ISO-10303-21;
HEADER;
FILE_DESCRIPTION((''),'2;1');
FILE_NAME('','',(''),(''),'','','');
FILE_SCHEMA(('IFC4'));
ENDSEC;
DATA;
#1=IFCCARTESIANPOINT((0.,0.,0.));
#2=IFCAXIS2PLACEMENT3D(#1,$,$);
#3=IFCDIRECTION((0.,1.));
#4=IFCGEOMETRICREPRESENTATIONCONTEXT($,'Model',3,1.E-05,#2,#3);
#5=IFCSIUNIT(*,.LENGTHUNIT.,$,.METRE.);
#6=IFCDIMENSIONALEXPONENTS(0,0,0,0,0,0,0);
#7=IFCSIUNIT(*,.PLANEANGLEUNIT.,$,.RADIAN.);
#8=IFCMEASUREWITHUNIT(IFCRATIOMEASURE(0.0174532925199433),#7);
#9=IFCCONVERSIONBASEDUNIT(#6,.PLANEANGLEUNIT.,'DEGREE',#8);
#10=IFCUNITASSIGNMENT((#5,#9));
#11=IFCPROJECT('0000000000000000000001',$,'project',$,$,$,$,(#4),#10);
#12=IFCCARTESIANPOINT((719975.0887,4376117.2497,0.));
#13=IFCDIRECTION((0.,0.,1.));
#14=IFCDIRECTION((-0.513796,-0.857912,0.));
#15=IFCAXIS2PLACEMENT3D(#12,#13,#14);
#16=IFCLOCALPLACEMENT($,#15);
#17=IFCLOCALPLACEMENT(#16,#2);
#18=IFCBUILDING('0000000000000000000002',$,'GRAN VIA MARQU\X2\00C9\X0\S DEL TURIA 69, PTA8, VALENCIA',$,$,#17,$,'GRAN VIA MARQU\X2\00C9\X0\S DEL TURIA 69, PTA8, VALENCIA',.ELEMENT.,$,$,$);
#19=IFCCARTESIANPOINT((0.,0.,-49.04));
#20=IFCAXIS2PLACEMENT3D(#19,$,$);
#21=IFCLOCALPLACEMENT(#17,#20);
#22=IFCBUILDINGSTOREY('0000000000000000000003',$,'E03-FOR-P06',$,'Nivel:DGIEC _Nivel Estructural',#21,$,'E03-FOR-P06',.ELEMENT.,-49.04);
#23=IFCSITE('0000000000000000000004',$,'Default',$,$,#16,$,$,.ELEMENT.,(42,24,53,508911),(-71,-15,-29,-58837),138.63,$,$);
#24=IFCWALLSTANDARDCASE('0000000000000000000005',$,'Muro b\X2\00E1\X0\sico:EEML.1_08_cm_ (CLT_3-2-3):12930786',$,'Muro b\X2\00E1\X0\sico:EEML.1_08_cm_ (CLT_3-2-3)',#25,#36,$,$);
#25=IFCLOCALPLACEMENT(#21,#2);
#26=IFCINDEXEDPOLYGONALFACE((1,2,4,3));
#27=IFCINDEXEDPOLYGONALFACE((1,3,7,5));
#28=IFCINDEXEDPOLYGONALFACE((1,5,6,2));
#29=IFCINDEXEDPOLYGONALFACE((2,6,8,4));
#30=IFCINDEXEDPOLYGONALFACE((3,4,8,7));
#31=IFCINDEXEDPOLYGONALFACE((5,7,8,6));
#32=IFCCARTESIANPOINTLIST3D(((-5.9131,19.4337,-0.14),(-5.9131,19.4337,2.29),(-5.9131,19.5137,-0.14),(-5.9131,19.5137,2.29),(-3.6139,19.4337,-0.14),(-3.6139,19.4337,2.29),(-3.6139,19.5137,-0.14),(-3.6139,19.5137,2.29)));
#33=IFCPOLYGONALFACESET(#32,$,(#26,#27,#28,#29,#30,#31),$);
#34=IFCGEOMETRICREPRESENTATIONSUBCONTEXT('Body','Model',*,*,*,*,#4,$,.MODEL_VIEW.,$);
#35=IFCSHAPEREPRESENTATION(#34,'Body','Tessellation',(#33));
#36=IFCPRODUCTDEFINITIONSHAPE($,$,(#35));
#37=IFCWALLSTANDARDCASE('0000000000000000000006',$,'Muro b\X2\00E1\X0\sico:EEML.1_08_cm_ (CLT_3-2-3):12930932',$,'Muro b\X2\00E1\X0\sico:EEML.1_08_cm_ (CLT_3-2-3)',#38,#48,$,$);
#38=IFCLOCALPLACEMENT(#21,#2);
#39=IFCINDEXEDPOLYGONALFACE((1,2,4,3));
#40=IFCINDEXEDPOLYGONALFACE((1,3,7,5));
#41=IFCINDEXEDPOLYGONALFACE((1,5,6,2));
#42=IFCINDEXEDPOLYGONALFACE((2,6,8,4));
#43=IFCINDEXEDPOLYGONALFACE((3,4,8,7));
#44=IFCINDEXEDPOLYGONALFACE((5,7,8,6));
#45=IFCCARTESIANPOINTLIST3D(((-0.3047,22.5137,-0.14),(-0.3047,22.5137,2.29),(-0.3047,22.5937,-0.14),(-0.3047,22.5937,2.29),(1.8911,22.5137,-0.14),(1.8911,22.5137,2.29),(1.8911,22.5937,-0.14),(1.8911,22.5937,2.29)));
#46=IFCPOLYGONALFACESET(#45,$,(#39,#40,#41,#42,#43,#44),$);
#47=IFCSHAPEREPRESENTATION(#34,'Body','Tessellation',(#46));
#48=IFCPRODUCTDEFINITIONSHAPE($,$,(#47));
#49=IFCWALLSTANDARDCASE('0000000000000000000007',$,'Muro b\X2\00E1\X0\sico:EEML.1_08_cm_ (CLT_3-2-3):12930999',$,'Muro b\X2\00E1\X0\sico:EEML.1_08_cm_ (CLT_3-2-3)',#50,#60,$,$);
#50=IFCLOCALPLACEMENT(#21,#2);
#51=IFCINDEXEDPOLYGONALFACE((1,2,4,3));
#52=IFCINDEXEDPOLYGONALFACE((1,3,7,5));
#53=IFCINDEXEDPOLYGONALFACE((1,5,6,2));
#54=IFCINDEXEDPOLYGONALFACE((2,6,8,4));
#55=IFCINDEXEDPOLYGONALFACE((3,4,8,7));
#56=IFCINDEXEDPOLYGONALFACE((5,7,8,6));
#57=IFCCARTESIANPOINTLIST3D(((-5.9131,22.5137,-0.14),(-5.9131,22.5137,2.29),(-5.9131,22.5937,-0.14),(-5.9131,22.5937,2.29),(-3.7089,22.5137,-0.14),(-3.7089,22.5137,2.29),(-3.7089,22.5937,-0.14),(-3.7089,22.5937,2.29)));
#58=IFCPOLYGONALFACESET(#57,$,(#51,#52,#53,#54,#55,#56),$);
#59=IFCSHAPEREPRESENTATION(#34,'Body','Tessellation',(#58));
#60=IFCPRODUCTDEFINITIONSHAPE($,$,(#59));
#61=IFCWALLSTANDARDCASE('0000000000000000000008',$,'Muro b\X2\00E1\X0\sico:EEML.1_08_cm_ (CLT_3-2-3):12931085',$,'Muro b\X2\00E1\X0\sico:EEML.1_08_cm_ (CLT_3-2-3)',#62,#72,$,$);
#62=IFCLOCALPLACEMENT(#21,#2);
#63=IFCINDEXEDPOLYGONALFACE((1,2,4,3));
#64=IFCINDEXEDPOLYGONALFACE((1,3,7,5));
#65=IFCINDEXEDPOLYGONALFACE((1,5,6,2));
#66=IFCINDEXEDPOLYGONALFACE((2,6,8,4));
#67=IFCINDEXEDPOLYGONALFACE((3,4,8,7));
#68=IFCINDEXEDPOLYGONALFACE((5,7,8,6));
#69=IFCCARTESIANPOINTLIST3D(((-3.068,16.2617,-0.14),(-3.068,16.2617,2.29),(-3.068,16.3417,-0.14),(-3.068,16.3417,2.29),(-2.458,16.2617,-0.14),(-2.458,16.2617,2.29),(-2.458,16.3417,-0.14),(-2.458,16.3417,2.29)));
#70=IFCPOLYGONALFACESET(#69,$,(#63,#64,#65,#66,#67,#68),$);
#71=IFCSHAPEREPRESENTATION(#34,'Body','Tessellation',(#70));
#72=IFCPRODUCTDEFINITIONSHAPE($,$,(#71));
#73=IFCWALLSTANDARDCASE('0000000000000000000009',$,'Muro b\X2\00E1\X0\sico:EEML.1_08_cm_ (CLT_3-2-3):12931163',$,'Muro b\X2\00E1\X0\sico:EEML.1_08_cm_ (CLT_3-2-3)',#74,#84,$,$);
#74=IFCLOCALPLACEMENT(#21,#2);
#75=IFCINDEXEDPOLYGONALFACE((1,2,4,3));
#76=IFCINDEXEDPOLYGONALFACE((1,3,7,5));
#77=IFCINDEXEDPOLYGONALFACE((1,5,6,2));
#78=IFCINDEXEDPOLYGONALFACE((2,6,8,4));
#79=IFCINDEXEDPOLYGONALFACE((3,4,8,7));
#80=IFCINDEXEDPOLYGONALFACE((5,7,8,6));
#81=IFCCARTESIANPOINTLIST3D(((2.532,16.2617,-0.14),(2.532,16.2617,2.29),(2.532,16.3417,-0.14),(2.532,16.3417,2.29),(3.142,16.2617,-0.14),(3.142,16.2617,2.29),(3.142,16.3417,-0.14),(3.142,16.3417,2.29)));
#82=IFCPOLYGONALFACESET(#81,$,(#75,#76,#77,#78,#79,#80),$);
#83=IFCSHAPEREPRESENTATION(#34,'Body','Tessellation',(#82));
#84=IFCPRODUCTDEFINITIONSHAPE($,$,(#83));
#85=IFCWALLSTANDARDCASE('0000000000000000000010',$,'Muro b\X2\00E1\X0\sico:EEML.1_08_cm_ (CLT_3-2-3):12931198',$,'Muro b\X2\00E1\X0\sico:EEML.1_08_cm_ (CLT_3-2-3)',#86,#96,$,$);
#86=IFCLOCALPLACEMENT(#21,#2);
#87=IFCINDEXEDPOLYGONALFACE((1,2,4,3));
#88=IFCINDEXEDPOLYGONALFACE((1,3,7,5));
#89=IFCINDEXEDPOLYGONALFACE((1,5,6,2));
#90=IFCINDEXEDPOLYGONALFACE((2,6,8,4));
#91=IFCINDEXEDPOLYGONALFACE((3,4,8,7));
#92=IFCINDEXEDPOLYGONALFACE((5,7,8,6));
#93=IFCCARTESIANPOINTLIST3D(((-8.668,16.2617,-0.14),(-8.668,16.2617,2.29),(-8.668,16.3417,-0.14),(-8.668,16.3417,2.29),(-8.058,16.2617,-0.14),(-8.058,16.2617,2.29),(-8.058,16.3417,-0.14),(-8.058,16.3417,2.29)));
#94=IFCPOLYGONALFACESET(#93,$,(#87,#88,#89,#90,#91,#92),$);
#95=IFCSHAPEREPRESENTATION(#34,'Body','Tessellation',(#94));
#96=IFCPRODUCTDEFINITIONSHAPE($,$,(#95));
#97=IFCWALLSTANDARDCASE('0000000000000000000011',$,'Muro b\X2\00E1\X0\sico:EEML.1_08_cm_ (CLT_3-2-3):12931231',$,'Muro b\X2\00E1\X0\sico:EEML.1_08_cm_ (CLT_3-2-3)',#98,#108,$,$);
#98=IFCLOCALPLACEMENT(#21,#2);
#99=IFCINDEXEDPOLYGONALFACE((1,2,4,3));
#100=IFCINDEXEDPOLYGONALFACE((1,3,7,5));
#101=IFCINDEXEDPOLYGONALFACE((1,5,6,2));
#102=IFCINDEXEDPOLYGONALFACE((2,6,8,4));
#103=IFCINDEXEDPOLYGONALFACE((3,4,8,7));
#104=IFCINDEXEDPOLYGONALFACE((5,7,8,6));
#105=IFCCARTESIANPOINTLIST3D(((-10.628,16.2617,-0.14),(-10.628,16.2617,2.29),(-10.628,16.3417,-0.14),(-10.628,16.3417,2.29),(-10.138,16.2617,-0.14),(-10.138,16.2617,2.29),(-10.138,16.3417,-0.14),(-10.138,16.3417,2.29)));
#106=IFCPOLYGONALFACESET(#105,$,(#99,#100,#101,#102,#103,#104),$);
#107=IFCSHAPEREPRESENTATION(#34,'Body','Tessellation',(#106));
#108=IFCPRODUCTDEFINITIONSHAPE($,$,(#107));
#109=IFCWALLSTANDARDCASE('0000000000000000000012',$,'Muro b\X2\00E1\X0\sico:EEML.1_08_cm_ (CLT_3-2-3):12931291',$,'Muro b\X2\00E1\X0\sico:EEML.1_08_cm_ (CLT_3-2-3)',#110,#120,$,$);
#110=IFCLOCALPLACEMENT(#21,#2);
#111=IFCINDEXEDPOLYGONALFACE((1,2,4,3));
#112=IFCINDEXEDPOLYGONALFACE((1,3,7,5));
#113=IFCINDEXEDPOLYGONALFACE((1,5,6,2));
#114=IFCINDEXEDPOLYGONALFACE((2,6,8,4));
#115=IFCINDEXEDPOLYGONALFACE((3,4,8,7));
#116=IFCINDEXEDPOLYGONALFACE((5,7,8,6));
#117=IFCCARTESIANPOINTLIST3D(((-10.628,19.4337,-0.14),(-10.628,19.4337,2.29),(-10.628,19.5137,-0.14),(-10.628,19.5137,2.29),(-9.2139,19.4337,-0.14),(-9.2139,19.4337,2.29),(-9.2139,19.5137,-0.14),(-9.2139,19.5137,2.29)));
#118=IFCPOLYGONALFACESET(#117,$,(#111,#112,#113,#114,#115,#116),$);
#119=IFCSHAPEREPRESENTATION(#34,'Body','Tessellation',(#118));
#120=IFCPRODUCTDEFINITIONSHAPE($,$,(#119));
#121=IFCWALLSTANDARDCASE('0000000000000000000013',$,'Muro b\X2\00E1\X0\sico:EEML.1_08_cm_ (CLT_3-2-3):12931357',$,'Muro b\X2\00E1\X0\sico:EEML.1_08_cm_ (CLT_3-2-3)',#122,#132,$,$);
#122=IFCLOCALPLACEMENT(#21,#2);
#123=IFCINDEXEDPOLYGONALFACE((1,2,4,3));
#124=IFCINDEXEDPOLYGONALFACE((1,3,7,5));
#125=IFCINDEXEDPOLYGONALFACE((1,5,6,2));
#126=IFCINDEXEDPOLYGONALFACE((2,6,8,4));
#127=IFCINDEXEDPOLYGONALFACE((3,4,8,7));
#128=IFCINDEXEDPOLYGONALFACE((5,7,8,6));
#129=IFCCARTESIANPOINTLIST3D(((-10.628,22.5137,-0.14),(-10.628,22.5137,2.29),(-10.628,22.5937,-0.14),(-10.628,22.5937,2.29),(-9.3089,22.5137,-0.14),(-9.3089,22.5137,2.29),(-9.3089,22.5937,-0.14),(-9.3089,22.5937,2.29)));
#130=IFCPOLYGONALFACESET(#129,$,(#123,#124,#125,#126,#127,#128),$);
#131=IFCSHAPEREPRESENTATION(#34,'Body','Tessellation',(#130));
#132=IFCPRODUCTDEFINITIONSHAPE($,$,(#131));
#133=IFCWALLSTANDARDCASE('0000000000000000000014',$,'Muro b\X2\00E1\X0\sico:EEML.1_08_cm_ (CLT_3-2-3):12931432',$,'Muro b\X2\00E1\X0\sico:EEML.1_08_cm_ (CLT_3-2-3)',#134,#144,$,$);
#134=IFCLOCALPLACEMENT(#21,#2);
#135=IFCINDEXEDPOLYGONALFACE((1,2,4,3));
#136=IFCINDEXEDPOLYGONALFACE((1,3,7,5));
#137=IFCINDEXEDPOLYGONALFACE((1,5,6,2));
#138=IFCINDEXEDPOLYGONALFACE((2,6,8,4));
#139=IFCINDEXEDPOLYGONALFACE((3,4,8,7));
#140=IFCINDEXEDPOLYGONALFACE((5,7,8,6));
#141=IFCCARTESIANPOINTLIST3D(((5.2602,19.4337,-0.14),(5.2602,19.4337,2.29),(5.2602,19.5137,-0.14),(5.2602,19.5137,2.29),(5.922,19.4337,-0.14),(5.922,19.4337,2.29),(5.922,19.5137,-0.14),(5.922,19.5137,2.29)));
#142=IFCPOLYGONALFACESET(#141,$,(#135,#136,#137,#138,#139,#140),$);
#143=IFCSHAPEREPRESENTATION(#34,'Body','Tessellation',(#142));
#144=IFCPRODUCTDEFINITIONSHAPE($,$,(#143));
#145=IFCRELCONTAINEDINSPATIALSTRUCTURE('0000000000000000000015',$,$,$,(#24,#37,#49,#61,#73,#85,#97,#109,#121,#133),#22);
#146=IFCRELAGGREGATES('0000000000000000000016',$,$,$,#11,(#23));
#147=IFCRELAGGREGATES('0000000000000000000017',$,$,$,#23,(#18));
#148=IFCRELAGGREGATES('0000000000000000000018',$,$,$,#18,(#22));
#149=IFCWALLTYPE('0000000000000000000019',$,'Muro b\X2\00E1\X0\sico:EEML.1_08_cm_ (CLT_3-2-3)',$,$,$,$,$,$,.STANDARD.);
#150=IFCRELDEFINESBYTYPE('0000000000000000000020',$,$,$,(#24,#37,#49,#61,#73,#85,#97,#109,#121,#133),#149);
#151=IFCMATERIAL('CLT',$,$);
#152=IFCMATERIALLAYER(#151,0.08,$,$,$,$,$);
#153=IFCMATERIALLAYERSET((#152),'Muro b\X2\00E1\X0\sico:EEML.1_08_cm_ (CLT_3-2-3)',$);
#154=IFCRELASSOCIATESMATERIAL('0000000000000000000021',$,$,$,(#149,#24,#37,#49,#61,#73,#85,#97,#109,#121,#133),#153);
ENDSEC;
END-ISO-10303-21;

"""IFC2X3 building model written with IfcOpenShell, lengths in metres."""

from ifc_helpers import new_model, entity, si_unit, converted_unit, direction, frame, frame_2d, origin, place, context, subcontext, project, spatial, rectangle, extrude, material, layer, layer_set, layer_usage, type_object, element, save


model = new_model("IFC2X3")

# Units and contexts
model_context = context("Model", 3, precision=1e-05, world=origin(), true_north=direction((0.0, 1.0)))
body_context = subcontext(model_context, "Body", "Model", "MODEL_VIEW")
ifc_project = project(units=[si_unit("LENGTHUNIT", "METRE"), converted_unit("PLANEANGLEUNIT", "DEGREE", entity("IfcRatioMeasure", 0.0174532925199433), si_unit("PLANEANGLEUNIT", "RADIAN"), dimensions=[0, 0, 0, 0, 0, 0, 0])], contexts=[model_context])

# Site, building, storey
site_placement = place(None, frame((719975.0887, 4376117.2497, 0.0), z_axis=(0.0, 0.0, 1.0), x_axis=(-0.513796, -0.857912, 0.0)))
site = spatial("IfcSite", under=ifc_project, at=site_placement, Name="Default", CompositionType="ELEMENT", RefLatitude=(42, 24, 53, 508911), RefLongitude=(-71, -15, -29, -58837), RefElevation=138.63)
building_placement = place(site_placement, origin())
building = spatial("IfcBuilding", under=site, at=building_placement, Name="GRAN VIA MARQUÉS DEL TURIA 69, PTA8, VALENCIA", LongName="GRAN VIA MARQUÉS DEL TURIA 69, PTA8, VALENCIA", CompositionType="ELEMENT")
storey_placement = place(building_placement, frame((0.0, 0.0, -49.04)))
storey = spatial("IfcBuildingStorey", under=building, at=storey_placement, Name="E03-FOR-P06", ObjectType="Nivel:DGIEC _Nivel Estructural", LongName="E03-FOR-P06", CompositionType="ELEMENT", Elevation=-49.04)

# Shared definitions
ifc_material = material(Name="CLT")

# Walls
ifc_layer_1 = layer(ifc_material, 0.08)
ifc_layer_set_1 = layer_set([ifc_layer_1], Name="Muro básico:EEML.1_08_cm_ (CLT_3-2-3)")
wall_type = type_object("IfcWallType", Name="Muro básico:EEML.1_08_cm_ (CLT_3-2-3)", PredefinedType="STANDARD", material=ifc_layer_set_1)
ifc_layer_usage_1 = layer_usage(ifc_layer_set_1, "AXIS2", "NEGATIVE", 0.04)
wall_1_placement = place(storey_placement, frame((-3.6139, 19.4737, -0.14), z_axis=(0.0, 0.0, 1.0), x_axis=(-1.0, 0.0, 0.0)))
element("IfcWallStandardCase", 1, at=wall_1_placement, inside=storey, type_object=wall_type, material=ifc_layer_usage_1, Name="Muro básico:EEML.1_08_cm_ (CLT_3-2-3):12930786", ObjectType="Muro básico:EEML.1_08_cm_ (CLT_3-2-3)", context=body_context, shape_type="SweptSolid", body=[
    extrude(rectangle(XDim=2.2992, YDim=0.08, at=frame_2d((1.1496, 0.0), x_axis=(-1.0, 0.0))), origin(), (0.0, 0.0, 1.0), 2.43),
])
ifc_layer_usage_2 = layer_usage(ifc_layer_set_1, "AXIS2", "NEGATIVE", 0.04)
wall_2_placement = place(storey_placement, frame((1.8911, 22.5537, -0.14), z_axis=(0.0, 0.0, 1.0), x_axis=(-1.0, 0.0, 0.0)))
element("IfcWallStandardCase", 2, at=wall_2_placement, inside=storey, type_object=wall_type, material=ifc_layer_usage_2, Name="Muro básico:EEML.1_08_cm_ (CLT_3-2-3):12930932", ObjectType="Muro básico:EEML.1_08_cm_ (CLT_3-2-3)", context=body_context, shape_type="SweptSolid", body=[
    extrude(rectangle(XDim=2.1958, YDim=0.08, at=frame_2d((1.0979, 0.0), x_axis=(-1.0, 0.0))), origin(), (0.0, 0.0, 1.0), 2.43),
])
ifc_layer_usage_3 = layer_usage(ifc_layer_set_1, "AXIS2", "NEGATIVE", 0.04)
wall_3_placement = place(storey_placement, frame((-3.7089, 22.5537, -0.14), z_axis=(0.0, 0.0, 1.0), x_axis=(-1.0, 0.0, 0.0)))
element("IfcWallStandardCase", 3, at=wall_3_placement, inside=storey, type_object=wall_type, material=ifc_layer_usage_3, Name="Muro básico:EEML.1_08_cm_ (CLT_3-2-3):12930999", ObjectType="Muro básico:EEML.1_08_cm_ (CLT_3-2-3)", context=body_context, shape_type="SweptSolid", body=[
    extrude(rectangle(XDim=2.2042, YDim=0.08, at=frame_2d((1.1021, 0.0), x_axis=(-1.0, 0.0))), origin(), (0.0, 0.0, 1.0), 2.43),
])
ifc_layer_usage_4 = layer_usage(ifc_layer_set_1, "AXIS2", "NEGATIVE", 0.04)
wall_4_placement = place(storey_placement, frame((-2.458, 16.3017, -0.14), z_axis=(0.0, 0.0, 1.0), x_axis=(-1.0, 0.0, 0.0)))
element("IfcWallStandardCase", 4, at=wall_4_placement, inside=storey, type_object=wall_type, material=ifc_layer_usage_4, Name="Muro básico:EEML.1_08_cm_ (CLT_3-2-3):12931085", ObjectType="Muro básico:EEML.1_08_cm_ (CLT_3-2-3)", context=body_context, shape_type="SweptSolid", body=[
    extrude(rectangle(XDim=0.61, YDim=0.08, at=frame_2d((0.305, 0.0), x_axis=(-1.0, 0.0))), origin(), (0.0, 0.0, 1.0), 2.43),
])
ifc_layer_usage_5 = layer_usage(ifc_layer_set_1, "AXIS2", "NEGATIVE", 0.04)
wall_5_placement = place(storey_placement, frame((3.142, 16.3017, -0.14), z_axis=(0.0, 0.0, 1.0), x_axis=(-1.0, 0.0, 0.0)))
element("IfcWallStandardCase", 5, at=wall_5_placement, inside=storey, type_object=wall_type, material=ifc_layer_usage_5, Name="Muro básico:EEML.1_08_cm_ (CLT_3-2-3):12931163", ObjectType="Muro básico:EEML.1_08_cm_ (CLT_3-2-3)", context=body_context, shape_type="SweptSolid", body=[
    extrude(rectangle(XDim=0.61, YDim=0.08, at=frame_2d((0.305, 0.0), x_axis=(-1.0, 0.0))), origin(), (0.0, 0.0, 1.0), 2.43),
])
ifc_layer_usage_6 = layer_usage(ifc_layer_set_1, "AXIS2", "NEGATIVE", 0.04)
wall_6_placement = place(storey_placement, frame((-8.058, 16.3017, -0.14), z_axis=(0.0, 0.0, 1.0), x_axis=(-1.0, 0.0, 0.0)))
element("IfcWallStandardCase", 6, at=wall_6_placement, inside=storey, type_object=wall_type, material=ifc_layer_usage_6, Name="Muro básico:EEML.1_08_cm_ (CLT_3-2-3):12931198", ObjectType="Muro básico:EEML.1_08_cm_ (CLT_3-2-3)", context=body_context, shape_type="SweptSolid", body=[
    extrude(rectangle(XDim=0.61, YDim=0.08, at=frame_2d((0.305, 0.0), x_axis=(-1.0, 0.0))), origin(), (0.0, 0.0, 1.0), 2.43),
])
ifc_layer_usage_7 = layer_usage(ifc_layer_set_1, "AXIS2", "NEGATIVE", 0.04)
wall_7_placement = place(storey_placement, frame((-10.138, 16.3017, -0.14), z_axis=(0.0, 0.0, 1.0), x_axis=(-1.0, 0.0, 0.0)))
element("IfcWallStandardCase", 7, at=wall_7_placement, inside=storey, type_object=wall_type, material=ifc_layer_usage_7, Name="Muro básico:EEML.1_08_cm_ (CLT_3-2-3):12931231", ObjectType="Muro básico:EEML.1_08_cm_ (CLT_3-2-3)", context=body_context, shape_type="SweptSolid", body=[
    extrude(rectangle(XDim=0.49, YDim=0.08, at=frame_2d((0.245, 0.0), x_axis=(-1.0, 0.0))), origin(), (0.0, 0.0, 1.0), 2.43),
])
ifc_layer_usage_8 = layer_usage(ifc_layer_set_1, "AXIS2", "NEGATIVE", 0.04)
wall_8_placement = place(storey_placement, frame((-9.2139, 19.4737, -0.14), z_axis=(0.0, 0.0, 1.0), x_axis=(-1.0, 0.0, 0.0)))
element("IfcWallStandardCase", 8, at=wall_8_placement, inside=storey, type_object=wall_type, material=ifc_layer_usage_8, Name="Muro básico:EEML.1_08_cm_ (CLT_3-2-3):12931291", ObjectType="Muro básico:EEML.1_08_cm_ (CLT_3-2-3)", context=body_context, shape_type="SweptSolid", body=[
    extrude(rectangle(XDim=1.4142, YDim=0.08, at=frame_2d((0.7071, 0.0), x_axis=(-1.0, 0.0))), origin(), (0.0, 0.0, 1.0), 2.43),
])
ifc_layer_usage_9 = layer_usage(ifc_layer_set_1, "AXIS2", "NEGATIVE", 0.04)
wall_9_placement = place(storey_placement, frame((-9.3089, 22.5537, -0.14), z_axis=(0.0, 0.0, 1.0), x_axis=(-1.0, 0.0, 0.0)))
element("IfcWallStandardCase", 9, at=wall_9_placement, inside=storey, type_object=wall_type, material=ifc_layer_usage_9, Name="Muro básico:EEML.1_08_cm_ (CLT_3-2-3):12931357", ObjectType="Muro básico:EEML.1_08_cm_ (CLT_3-2-3)", context=body_context, shape_type="SweptSolid", body=[
    extrude(rectangle(XDim=1.3192, YDim=0.08, at=frame_2d((0.6596, 0.0), x_axis=(-1.0, 0.0))), origin(), (0.0, 0.0, 1.0), 2.43),
])
ifc_layer_usage_10 = layer_usage(ifc_layer_set_1, "AXIS2", "NEGATIVE", 0.04)
wall_10_placement = place(storey_placement, frame((5.922, 19.4737, -0.14), z_axis=(0.0, 0.0, 1.0), x_axis=(-1.0, 0.0, 0.0)))
element("IfcWallStandardCase", 10, at=wall_10_placement, inside=storey, type_object=wall_type, material=ifc_layer_usage_10, Name="Muro básico:EEML.1_08_cm_ (CLT_3-2-3):12931432", ObjectType="Muro básico:EEML.1_08_cm_ (CLT_3-2-3)", context=body_context, shape_type="SweptSolid", body=[
    extrude(rectangle(XDim=0.6618, YDim=0.08, at=frame_2d((0.3309, 0.0), x_axis=(-1.0, 0.0))), origin(), (0.0, 0.0, 1.0), 2.43),
])

save(model, "model.ifc")
